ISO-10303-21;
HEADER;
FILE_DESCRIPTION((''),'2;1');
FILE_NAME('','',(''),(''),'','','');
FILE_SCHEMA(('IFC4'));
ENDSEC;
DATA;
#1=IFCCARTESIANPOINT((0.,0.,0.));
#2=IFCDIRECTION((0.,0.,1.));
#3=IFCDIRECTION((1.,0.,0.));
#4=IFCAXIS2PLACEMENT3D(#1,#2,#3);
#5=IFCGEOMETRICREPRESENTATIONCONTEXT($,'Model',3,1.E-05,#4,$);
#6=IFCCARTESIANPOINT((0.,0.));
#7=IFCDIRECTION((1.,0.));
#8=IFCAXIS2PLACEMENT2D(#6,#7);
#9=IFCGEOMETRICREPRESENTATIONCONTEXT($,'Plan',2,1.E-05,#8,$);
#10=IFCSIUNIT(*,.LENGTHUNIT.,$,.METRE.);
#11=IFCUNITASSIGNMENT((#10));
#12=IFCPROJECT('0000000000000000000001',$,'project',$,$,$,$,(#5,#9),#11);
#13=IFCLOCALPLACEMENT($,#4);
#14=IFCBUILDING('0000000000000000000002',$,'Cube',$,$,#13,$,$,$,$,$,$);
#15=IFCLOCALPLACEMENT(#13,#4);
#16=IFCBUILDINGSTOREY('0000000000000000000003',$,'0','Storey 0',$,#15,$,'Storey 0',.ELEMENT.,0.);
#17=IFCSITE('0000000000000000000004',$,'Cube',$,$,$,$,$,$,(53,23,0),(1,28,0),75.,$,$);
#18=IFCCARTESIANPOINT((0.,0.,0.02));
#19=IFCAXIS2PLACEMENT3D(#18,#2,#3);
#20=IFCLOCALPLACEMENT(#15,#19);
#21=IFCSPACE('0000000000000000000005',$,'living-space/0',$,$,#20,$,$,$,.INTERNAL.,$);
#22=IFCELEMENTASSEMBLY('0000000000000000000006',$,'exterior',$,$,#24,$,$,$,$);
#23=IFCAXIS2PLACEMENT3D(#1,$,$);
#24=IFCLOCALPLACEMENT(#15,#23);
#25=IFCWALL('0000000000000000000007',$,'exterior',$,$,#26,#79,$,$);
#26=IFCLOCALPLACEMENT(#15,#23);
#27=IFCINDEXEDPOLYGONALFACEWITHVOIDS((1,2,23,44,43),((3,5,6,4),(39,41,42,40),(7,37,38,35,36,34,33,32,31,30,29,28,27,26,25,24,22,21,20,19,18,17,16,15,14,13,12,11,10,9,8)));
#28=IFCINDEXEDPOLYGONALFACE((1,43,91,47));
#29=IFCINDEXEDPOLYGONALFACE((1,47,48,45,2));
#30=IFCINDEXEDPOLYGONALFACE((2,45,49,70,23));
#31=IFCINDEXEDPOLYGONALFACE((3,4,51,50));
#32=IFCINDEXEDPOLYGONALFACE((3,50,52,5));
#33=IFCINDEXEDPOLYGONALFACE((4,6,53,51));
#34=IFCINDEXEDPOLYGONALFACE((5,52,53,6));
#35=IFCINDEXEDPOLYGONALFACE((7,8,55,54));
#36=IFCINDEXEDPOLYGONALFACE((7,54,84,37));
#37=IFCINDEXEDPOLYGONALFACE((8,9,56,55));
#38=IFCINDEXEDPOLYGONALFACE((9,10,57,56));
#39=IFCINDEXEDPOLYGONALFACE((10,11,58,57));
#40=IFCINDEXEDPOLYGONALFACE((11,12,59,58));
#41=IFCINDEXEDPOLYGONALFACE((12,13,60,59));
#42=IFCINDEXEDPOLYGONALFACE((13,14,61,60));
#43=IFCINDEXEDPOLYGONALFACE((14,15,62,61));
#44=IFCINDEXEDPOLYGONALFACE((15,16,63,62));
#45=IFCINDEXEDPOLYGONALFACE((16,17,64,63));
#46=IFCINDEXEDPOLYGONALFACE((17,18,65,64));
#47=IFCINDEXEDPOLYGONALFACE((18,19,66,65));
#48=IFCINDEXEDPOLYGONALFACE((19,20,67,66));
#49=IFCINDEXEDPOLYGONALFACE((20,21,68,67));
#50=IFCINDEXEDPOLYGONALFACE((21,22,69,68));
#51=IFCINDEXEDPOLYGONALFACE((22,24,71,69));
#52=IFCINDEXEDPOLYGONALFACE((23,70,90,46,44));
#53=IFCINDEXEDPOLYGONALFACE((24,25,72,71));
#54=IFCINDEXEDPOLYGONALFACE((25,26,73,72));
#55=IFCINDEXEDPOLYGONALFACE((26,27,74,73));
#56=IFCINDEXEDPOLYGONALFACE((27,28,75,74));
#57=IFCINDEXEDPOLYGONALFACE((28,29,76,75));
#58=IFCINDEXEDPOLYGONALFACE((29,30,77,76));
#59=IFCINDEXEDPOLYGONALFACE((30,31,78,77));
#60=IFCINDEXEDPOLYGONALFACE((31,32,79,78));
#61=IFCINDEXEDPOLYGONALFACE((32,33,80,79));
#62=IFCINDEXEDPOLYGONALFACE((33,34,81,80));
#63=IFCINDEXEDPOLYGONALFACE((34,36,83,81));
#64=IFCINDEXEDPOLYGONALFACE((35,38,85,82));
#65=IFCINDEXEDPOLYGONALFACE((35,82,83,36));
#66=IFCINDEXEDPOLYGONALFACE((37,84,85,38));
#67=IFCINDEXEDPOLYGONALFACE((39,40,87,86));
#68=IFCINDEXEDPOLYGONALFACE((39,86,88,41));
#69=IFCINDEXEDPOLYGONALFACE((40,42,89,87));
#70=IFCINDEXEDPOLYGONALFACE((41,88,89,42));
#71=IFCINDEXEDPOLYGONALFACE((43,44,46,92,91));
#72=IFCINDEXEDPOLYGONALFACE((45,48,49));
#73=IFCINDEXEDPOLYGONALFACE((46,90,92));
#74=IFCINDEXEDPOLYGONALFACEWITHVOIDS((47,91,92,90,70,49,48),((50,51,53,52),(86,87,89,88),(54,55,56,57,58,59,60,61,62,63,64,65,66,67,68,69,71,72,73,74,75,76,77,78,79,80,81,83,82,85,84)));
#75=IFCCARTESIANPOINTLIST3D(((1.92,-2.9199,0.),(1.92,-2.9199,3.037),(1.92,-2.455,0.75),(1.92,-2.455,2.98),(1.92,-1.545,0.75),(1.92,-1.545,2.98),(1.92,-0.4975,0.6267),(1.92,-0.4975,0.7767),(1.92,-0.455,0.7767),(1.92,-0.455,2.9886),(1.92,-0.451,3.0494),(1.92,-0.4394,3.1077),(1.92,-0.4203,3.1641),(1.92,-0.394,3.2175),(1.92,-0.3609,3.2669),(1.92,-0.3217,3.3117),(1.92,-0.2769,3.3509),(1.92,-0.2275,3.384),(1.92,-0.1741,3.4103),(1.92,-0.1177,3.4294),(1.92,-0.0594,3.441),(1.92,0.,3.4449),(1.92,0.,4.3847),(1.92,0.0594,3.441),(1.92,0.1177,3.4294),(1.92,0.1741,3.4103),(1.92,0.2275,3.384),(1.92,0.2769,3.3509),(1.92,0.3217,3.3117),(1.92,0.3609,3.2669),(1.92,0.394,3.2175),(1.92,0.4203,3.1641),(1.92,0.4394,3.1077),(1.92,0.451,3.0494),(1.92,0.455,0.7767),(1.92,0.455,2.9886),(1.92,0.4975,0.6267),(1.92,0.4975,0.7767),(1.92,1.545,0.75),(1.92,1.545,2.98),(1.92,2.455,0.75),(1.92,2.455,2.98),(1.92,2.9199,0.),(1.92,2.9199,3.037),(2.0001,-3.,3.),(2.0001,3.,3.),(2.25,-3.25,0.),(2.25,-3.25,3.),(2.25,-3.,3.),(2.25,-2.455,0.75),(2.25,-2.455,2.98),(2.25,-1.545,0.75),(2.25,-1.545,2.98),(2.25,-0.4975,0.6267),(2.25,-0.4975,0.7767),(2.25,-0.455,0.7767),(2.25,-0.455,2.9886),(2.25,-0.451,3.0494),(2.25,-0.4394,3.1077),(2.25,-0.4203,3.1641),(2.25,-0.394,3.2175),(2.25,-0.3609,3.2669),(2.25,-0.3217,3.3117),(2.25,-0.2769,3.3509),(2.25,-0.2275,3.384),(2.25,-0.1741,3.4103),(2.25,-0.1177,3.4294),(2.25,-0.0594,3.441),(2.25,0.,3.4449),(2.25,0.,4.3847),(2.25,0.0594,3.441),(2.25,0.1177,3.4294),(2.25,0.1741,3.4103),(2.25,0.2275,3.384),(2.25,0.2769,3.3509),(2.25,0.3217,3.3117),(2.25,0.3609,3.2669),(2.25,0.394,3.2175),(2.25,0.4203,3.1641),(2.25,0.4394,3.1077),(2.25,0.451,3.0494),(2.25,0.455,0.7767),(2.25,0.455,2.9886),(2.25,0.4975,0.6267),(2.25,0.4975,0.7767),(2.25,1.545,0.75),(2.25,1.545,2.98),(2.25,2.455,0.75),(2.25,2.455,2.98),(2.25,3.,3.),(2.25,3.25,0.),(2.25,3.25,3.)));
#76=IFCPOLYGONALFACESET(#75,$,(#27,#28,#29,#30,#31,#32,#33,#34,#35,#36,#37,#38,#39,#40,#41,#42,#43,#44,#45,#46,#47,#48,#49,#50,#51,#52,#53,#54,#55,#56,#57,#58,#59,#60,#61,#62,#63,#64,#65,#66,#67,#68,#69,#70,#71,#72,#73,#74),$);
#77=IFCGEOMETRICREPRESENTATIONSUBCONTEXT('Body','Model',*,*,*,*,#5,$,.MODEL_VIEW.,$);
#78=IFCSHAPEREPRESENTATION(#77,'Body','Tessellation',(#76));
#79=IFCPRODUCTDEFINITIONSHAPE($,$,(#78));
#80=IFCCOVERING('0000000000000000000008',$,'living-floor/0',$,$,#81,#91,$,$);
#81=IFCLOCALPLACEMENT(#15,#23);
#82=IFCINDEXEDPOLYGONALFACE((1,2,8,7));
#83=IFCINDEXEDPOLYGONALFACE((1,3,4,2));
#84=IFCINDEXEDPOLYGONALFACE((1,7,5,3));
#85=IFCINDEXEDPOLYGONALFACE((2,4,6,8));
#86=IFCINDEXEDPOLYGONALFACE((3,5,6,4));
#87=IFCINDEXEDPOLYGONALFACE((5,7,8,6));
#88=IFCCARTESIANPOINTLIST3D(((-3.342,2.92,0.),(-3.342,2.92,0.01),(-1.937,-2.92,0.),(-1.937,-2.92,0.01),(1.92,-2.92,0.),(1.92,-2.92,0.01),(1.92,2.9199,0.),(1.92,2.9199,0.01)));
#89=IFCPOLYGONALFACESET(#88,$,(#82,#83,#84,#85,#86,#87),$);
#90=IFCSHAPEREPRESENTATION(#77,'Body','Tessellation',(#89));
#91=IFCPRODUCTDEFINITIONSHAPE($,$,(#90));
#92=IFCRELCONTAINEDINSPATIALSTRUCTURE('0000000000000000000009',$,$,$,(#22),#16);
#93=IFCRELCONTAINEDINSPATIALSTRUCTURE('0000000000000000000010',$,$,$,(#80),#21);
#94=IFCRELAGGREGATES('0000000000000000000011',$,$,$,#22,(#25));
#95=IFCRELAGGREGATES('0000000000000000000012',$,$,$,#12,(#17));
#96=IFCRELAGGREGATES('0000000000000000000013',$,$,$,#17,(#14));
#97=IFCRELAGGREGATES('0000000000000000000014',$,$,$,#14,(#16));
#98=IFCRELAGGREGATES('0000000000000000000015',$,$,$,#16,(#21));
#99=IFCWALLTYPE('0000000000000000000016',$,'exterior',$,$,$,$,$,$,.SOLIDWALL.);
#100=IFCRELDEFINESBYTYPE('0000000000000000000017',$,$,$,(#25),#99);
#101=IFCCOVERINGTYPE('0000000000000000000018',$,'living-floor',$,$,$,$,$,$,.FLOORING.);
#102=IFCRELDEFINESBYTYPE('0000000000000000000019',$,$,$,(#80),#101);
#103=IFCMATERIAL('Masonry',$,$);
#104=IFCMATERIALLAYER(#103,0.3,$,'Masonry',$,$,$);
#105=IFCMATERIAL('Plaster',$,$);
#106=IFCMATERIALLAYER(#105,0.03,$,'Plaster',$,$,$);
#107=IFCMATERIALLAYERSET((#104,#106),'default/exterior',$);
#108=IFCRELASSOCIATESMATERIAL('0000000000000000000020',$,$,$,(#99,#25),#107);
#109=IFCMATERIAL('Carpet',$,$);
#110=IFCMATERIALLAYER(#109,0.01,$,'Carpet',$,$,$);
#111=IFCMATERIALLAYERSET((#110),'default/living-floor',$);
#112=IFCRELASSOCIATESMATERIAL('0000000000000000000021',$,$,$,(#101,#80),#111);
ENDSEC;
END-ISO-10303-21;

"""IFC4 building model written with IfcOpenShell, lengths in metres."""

from ifc_helpers import new_model, si_unit, frame, origin, origin_with_axes, origin_2d_with_axis, place, context, subcontext, project, spatial, polyline, outline, extrude, clip, bounded_halfspace, material, layer, layer_set, layer_usage, type_object, element, aggregate, save


model = new_model("IFC4")

# Units and contexts
model_context = context("Model", 3, precision=1e-05, world=origin_with_axes())
plan_context = context("Plan", 2, precision=1e-05, world=origin_2d_with_axis())
body_context = subcontext(model_context, "Body", "Model", "MODEL_VIEW")
ifc_project = project(units=[si_unit("LENGTHUNIT", "METRE")], contexts=[model_context, plan_context])

# Site, building, storey
site = spatial("IfcSite", under=ifc_project, Name="Cube", RefLatitude=(53, 23, 0), RefLongitude=(1, 28, 0), RefElevation=75.0)
building_placement = place(None, origin_with_axes())
building = spatial("IfcBuilding", under=site, at=building_placement, Name="Cube")
storey_placement = place(building_placement, origin_with_axes())
storey = spatial("IfcBuildingStorey", under=building, at=storey_placement, Name="0", Description="Storey 0", LongName="Storey 0", CompositionType="ELEMENT", Elevation=0.0)

# Element assembly, wall, openings
ifc_material_1 = material(Name="Masonry")
ifc_layer_1 = layer(ifc_material_1, 0.3, Name="Masonry")
ifc_material_2 = material(Name="Plaster")
ifc_layer_2 = layer(ifc_material_2, 0.03, Name="Plaster")
ifc_layer_set_1 = layer_set([ifc_layer_1, ifc_layer_2], Name="default/exterior")
wall_type = type_object("IfcWallType", Name="exterior", PredefinedType="SOLIDWALL", material=ifc_layer_set_1)
assembly_1_placement = place(storey_placement, frame((2.0, -3.0, 0.0), z_axis=(0.0, 0.0, 1.0), x_axis=(0.0, 1.0, 0.0)))
assembly_1 = element("IfcElementAssembly", 1, at=assembly_1_placement, inside=storey, Name="exterior")
ifc_layer_usage_1 = layer_usage(ifc_layer_set_1, "AXIS2", "POSITIVE", -0.25)
wall_1_placement = place(assembly_1_placement, origin_with_axes())
wall_1 = element("IfcWall", 2, at=wall_1_placement, type_object=wall_type, material=ifc_layer_usage_1, Name="exterior", context=body_context, shape_type="Clipping", body=[
    clip(clip(clip(clip(extrude(outline(polyline([(0.0801, 0.08), (-0.25, -0.25), (6.25, -0.25), (5.9199, 0.08), (0.0801, 0.08)])), origin(), (0.0, 0.0, 1.0), 4.385), bounded_halfspace(frame((6.0, 0.0, 3.0), z_axis=(0.419069, 0.0, 0.907954), x_axis=(0.0, -1.0, 0.0)), False, origin(), polyline([(6.0, -1.0), (3.0, -1.0), (3.0, 1.0), (6.0, 1.0), (6.0, -1.0)]))), bounded_halfspace(frame((6.0, 0.0, 3.0), z_axis=(0.0, 0.0, 1.0), x_axis=(0.0, 1.0, 0.0)), False, origin(), polyline([(6.0, 1.0), (7.0, 1.0), (7.0, -1.0), (6.0, -1.0), (6.0, 1.0)]))), bounded_halfspace(frame((3.0, 0.0, 4.3847), z_axis=(-0.419069, 0.0, 0.907954), x_axis=(0.0, -1.0, 0.0)), False, origin(), polyline([(3.0, -1.0), (0.0, -1.0), (0.0, 1.0), (3.0, 1.0), (3.0, -1.0)]))), bounded_halfspace(frame((0.0, 0.0, 3.0), z_axis=(0.0, 0.0, 1.0), x_axis=(0.0, -1.0, 0.0)), False, origin(), polyline([(0.0, -1.0), (-1.0, -1.0), (-1.0, 1.0), (0.0, 1.0), (0.0, -1.0)]))),
])
opening_1_placement = place(wall_1_placement, frame((0.545, -0.25, 0.75), z_axis=(0.0, 0.0, 1.0), x_axis=(1.0, 0.0, 0.0)))
element("IfcOpeningElement", 3, at=opening_1_placement, cuts=wall_1, PredefinedType="OPENING", context=body_context, shape_type="SweptSolid", body=[
    extrude(outline(polyline([(0.0, -0.02), (0.91, -0.02), (0.91, 0.35), (0.0, 0.35), (0.0, -0.02)])), origin(), (0.0, 0.0, 1.0), 2.23),
])
opening_2_placement = place(wall_1_placement, frame((2.545, -0.25, 0.75), z_axis=(0.0, 0.0, 1.0), x_axis=(1.0, 0.0, 0.0)))
element("IfcOpeningElement", 4, at=opening_2_placement, cuts=wall_1, PredefinedType="OPENING", context=body_context, shape_type="SweptSolid", body=[
    extrude(outline(polyline([(0.1333, 2.5617), (0.1781, 2.6009), (0.2275, 2.634), (0.2809, 2.6603), (0.3373, 2.6794), (0.3956, 2.691), (0.455, 2.6949), (0.5144, 2.691), (0.5727, 2.6794), (0.6291, 2.6603), (0.6825, 2.634), (0.7319, 2.6009), (0.7767, 2.5617), (0.8159, 2.5169), (0.849, 2.4675), (0.8753, 2.4141), (0.8944, 2.3577), (0.906, 2.2994), (0.91, 2.2386), (0.91, 2.2069), (0.91, 0.0267), (0.9525, 0.0267), (0.9525, -0.1233), (-0.0425, -0.1233), (-0.0425, 0.0267), (0.0, 0.0267), (0.0, 2.2069), (0.0, 2.2386), (0.004, 2.2994), (0.0156, 2.3577), (0.0347, 2.4141), (0.061, 2.4675), (0.0941, 2.5169), (0.1333, 2.5617)])), frame((0.0, -0.02, 0.0), z_axis=(0.0, -1.0, 0.0), x_axis=(1.0, 0.0, 0.0)), (0.0, 0.0, -1.0), 0.37),
])
opening_3_placement = place(wall_1_placement, frame((4.545, -0.25, 0.75), z_axis=(0.0, 0.0, 1.0), x_axis=(1.0, 0.0, 0.0)))
element("IfcOpeningElement", 5, at=opening_3_placement, cuts=wall_1, PredefinedType="OPENING", context=body_context, shape_type="SweptSolid", body=[
    extrude(outline(polyline([(0.0, -0.02), (0.91, -0.02), (0.91, 0.35), (0.0, 0.35), (0.0, -0.02)])), origin(), (0.0, 0.0, 1.0), 2.23),
])
aggregate(assembly_1, [wall_1])

# Shared definitions
space_placement = place(storey_placement, frame((0.0, 0.0, 0.02), z_axis=(0.0, 0.0, 1.0), x_axis=(1.0, 0.0, 0.0)))
space = spatial("IfcSpace", under=storey, at=space_placement, Name="living-space/0", PredefinedType="INTERNAL")

# Covering
ifc_material_3 = material(Name="Carpet")
ifc_layer_3 = layer(ifc_material_3, 0.01, Name="Carpet")
ifc_layer_set_2 = layer_set([ifc_layer_3], Name="default/living-floor")
ifc_layer_usage_2 = layer_usage(ifc_layer_set_2, "AXIS3", "POSITIVE", 0.0)
covering_type = type_object("IfcCoveringType", Name="living-floor", PredefinedType="FLOORING", material=ifc_layer_set_2)
covering_placement = place(space_placement, frame((0.0, 0.0, -0.02), z_axis=(0.0, 0.0, 1.0), x_axis=(1.0, 0.0, 0.0)))
element("IfcCovering", 6, at=covering_placement, inside=space, type_object=covering_type, material=ifc_layer_usage_2, Name="living-floor/0", context=body_context, shape_type="SweptSolid", body=[
    extrude(outline(polyline([(1.92, 2.9199), (-3.342, 2.92), (-1.937, -2.92), (1.92, -2.92), (1.92, 2.9199)])), origin_with_axes(), (0.0, 0.0, 1.0), 0.01),
])

save(model, "model.ifc")
